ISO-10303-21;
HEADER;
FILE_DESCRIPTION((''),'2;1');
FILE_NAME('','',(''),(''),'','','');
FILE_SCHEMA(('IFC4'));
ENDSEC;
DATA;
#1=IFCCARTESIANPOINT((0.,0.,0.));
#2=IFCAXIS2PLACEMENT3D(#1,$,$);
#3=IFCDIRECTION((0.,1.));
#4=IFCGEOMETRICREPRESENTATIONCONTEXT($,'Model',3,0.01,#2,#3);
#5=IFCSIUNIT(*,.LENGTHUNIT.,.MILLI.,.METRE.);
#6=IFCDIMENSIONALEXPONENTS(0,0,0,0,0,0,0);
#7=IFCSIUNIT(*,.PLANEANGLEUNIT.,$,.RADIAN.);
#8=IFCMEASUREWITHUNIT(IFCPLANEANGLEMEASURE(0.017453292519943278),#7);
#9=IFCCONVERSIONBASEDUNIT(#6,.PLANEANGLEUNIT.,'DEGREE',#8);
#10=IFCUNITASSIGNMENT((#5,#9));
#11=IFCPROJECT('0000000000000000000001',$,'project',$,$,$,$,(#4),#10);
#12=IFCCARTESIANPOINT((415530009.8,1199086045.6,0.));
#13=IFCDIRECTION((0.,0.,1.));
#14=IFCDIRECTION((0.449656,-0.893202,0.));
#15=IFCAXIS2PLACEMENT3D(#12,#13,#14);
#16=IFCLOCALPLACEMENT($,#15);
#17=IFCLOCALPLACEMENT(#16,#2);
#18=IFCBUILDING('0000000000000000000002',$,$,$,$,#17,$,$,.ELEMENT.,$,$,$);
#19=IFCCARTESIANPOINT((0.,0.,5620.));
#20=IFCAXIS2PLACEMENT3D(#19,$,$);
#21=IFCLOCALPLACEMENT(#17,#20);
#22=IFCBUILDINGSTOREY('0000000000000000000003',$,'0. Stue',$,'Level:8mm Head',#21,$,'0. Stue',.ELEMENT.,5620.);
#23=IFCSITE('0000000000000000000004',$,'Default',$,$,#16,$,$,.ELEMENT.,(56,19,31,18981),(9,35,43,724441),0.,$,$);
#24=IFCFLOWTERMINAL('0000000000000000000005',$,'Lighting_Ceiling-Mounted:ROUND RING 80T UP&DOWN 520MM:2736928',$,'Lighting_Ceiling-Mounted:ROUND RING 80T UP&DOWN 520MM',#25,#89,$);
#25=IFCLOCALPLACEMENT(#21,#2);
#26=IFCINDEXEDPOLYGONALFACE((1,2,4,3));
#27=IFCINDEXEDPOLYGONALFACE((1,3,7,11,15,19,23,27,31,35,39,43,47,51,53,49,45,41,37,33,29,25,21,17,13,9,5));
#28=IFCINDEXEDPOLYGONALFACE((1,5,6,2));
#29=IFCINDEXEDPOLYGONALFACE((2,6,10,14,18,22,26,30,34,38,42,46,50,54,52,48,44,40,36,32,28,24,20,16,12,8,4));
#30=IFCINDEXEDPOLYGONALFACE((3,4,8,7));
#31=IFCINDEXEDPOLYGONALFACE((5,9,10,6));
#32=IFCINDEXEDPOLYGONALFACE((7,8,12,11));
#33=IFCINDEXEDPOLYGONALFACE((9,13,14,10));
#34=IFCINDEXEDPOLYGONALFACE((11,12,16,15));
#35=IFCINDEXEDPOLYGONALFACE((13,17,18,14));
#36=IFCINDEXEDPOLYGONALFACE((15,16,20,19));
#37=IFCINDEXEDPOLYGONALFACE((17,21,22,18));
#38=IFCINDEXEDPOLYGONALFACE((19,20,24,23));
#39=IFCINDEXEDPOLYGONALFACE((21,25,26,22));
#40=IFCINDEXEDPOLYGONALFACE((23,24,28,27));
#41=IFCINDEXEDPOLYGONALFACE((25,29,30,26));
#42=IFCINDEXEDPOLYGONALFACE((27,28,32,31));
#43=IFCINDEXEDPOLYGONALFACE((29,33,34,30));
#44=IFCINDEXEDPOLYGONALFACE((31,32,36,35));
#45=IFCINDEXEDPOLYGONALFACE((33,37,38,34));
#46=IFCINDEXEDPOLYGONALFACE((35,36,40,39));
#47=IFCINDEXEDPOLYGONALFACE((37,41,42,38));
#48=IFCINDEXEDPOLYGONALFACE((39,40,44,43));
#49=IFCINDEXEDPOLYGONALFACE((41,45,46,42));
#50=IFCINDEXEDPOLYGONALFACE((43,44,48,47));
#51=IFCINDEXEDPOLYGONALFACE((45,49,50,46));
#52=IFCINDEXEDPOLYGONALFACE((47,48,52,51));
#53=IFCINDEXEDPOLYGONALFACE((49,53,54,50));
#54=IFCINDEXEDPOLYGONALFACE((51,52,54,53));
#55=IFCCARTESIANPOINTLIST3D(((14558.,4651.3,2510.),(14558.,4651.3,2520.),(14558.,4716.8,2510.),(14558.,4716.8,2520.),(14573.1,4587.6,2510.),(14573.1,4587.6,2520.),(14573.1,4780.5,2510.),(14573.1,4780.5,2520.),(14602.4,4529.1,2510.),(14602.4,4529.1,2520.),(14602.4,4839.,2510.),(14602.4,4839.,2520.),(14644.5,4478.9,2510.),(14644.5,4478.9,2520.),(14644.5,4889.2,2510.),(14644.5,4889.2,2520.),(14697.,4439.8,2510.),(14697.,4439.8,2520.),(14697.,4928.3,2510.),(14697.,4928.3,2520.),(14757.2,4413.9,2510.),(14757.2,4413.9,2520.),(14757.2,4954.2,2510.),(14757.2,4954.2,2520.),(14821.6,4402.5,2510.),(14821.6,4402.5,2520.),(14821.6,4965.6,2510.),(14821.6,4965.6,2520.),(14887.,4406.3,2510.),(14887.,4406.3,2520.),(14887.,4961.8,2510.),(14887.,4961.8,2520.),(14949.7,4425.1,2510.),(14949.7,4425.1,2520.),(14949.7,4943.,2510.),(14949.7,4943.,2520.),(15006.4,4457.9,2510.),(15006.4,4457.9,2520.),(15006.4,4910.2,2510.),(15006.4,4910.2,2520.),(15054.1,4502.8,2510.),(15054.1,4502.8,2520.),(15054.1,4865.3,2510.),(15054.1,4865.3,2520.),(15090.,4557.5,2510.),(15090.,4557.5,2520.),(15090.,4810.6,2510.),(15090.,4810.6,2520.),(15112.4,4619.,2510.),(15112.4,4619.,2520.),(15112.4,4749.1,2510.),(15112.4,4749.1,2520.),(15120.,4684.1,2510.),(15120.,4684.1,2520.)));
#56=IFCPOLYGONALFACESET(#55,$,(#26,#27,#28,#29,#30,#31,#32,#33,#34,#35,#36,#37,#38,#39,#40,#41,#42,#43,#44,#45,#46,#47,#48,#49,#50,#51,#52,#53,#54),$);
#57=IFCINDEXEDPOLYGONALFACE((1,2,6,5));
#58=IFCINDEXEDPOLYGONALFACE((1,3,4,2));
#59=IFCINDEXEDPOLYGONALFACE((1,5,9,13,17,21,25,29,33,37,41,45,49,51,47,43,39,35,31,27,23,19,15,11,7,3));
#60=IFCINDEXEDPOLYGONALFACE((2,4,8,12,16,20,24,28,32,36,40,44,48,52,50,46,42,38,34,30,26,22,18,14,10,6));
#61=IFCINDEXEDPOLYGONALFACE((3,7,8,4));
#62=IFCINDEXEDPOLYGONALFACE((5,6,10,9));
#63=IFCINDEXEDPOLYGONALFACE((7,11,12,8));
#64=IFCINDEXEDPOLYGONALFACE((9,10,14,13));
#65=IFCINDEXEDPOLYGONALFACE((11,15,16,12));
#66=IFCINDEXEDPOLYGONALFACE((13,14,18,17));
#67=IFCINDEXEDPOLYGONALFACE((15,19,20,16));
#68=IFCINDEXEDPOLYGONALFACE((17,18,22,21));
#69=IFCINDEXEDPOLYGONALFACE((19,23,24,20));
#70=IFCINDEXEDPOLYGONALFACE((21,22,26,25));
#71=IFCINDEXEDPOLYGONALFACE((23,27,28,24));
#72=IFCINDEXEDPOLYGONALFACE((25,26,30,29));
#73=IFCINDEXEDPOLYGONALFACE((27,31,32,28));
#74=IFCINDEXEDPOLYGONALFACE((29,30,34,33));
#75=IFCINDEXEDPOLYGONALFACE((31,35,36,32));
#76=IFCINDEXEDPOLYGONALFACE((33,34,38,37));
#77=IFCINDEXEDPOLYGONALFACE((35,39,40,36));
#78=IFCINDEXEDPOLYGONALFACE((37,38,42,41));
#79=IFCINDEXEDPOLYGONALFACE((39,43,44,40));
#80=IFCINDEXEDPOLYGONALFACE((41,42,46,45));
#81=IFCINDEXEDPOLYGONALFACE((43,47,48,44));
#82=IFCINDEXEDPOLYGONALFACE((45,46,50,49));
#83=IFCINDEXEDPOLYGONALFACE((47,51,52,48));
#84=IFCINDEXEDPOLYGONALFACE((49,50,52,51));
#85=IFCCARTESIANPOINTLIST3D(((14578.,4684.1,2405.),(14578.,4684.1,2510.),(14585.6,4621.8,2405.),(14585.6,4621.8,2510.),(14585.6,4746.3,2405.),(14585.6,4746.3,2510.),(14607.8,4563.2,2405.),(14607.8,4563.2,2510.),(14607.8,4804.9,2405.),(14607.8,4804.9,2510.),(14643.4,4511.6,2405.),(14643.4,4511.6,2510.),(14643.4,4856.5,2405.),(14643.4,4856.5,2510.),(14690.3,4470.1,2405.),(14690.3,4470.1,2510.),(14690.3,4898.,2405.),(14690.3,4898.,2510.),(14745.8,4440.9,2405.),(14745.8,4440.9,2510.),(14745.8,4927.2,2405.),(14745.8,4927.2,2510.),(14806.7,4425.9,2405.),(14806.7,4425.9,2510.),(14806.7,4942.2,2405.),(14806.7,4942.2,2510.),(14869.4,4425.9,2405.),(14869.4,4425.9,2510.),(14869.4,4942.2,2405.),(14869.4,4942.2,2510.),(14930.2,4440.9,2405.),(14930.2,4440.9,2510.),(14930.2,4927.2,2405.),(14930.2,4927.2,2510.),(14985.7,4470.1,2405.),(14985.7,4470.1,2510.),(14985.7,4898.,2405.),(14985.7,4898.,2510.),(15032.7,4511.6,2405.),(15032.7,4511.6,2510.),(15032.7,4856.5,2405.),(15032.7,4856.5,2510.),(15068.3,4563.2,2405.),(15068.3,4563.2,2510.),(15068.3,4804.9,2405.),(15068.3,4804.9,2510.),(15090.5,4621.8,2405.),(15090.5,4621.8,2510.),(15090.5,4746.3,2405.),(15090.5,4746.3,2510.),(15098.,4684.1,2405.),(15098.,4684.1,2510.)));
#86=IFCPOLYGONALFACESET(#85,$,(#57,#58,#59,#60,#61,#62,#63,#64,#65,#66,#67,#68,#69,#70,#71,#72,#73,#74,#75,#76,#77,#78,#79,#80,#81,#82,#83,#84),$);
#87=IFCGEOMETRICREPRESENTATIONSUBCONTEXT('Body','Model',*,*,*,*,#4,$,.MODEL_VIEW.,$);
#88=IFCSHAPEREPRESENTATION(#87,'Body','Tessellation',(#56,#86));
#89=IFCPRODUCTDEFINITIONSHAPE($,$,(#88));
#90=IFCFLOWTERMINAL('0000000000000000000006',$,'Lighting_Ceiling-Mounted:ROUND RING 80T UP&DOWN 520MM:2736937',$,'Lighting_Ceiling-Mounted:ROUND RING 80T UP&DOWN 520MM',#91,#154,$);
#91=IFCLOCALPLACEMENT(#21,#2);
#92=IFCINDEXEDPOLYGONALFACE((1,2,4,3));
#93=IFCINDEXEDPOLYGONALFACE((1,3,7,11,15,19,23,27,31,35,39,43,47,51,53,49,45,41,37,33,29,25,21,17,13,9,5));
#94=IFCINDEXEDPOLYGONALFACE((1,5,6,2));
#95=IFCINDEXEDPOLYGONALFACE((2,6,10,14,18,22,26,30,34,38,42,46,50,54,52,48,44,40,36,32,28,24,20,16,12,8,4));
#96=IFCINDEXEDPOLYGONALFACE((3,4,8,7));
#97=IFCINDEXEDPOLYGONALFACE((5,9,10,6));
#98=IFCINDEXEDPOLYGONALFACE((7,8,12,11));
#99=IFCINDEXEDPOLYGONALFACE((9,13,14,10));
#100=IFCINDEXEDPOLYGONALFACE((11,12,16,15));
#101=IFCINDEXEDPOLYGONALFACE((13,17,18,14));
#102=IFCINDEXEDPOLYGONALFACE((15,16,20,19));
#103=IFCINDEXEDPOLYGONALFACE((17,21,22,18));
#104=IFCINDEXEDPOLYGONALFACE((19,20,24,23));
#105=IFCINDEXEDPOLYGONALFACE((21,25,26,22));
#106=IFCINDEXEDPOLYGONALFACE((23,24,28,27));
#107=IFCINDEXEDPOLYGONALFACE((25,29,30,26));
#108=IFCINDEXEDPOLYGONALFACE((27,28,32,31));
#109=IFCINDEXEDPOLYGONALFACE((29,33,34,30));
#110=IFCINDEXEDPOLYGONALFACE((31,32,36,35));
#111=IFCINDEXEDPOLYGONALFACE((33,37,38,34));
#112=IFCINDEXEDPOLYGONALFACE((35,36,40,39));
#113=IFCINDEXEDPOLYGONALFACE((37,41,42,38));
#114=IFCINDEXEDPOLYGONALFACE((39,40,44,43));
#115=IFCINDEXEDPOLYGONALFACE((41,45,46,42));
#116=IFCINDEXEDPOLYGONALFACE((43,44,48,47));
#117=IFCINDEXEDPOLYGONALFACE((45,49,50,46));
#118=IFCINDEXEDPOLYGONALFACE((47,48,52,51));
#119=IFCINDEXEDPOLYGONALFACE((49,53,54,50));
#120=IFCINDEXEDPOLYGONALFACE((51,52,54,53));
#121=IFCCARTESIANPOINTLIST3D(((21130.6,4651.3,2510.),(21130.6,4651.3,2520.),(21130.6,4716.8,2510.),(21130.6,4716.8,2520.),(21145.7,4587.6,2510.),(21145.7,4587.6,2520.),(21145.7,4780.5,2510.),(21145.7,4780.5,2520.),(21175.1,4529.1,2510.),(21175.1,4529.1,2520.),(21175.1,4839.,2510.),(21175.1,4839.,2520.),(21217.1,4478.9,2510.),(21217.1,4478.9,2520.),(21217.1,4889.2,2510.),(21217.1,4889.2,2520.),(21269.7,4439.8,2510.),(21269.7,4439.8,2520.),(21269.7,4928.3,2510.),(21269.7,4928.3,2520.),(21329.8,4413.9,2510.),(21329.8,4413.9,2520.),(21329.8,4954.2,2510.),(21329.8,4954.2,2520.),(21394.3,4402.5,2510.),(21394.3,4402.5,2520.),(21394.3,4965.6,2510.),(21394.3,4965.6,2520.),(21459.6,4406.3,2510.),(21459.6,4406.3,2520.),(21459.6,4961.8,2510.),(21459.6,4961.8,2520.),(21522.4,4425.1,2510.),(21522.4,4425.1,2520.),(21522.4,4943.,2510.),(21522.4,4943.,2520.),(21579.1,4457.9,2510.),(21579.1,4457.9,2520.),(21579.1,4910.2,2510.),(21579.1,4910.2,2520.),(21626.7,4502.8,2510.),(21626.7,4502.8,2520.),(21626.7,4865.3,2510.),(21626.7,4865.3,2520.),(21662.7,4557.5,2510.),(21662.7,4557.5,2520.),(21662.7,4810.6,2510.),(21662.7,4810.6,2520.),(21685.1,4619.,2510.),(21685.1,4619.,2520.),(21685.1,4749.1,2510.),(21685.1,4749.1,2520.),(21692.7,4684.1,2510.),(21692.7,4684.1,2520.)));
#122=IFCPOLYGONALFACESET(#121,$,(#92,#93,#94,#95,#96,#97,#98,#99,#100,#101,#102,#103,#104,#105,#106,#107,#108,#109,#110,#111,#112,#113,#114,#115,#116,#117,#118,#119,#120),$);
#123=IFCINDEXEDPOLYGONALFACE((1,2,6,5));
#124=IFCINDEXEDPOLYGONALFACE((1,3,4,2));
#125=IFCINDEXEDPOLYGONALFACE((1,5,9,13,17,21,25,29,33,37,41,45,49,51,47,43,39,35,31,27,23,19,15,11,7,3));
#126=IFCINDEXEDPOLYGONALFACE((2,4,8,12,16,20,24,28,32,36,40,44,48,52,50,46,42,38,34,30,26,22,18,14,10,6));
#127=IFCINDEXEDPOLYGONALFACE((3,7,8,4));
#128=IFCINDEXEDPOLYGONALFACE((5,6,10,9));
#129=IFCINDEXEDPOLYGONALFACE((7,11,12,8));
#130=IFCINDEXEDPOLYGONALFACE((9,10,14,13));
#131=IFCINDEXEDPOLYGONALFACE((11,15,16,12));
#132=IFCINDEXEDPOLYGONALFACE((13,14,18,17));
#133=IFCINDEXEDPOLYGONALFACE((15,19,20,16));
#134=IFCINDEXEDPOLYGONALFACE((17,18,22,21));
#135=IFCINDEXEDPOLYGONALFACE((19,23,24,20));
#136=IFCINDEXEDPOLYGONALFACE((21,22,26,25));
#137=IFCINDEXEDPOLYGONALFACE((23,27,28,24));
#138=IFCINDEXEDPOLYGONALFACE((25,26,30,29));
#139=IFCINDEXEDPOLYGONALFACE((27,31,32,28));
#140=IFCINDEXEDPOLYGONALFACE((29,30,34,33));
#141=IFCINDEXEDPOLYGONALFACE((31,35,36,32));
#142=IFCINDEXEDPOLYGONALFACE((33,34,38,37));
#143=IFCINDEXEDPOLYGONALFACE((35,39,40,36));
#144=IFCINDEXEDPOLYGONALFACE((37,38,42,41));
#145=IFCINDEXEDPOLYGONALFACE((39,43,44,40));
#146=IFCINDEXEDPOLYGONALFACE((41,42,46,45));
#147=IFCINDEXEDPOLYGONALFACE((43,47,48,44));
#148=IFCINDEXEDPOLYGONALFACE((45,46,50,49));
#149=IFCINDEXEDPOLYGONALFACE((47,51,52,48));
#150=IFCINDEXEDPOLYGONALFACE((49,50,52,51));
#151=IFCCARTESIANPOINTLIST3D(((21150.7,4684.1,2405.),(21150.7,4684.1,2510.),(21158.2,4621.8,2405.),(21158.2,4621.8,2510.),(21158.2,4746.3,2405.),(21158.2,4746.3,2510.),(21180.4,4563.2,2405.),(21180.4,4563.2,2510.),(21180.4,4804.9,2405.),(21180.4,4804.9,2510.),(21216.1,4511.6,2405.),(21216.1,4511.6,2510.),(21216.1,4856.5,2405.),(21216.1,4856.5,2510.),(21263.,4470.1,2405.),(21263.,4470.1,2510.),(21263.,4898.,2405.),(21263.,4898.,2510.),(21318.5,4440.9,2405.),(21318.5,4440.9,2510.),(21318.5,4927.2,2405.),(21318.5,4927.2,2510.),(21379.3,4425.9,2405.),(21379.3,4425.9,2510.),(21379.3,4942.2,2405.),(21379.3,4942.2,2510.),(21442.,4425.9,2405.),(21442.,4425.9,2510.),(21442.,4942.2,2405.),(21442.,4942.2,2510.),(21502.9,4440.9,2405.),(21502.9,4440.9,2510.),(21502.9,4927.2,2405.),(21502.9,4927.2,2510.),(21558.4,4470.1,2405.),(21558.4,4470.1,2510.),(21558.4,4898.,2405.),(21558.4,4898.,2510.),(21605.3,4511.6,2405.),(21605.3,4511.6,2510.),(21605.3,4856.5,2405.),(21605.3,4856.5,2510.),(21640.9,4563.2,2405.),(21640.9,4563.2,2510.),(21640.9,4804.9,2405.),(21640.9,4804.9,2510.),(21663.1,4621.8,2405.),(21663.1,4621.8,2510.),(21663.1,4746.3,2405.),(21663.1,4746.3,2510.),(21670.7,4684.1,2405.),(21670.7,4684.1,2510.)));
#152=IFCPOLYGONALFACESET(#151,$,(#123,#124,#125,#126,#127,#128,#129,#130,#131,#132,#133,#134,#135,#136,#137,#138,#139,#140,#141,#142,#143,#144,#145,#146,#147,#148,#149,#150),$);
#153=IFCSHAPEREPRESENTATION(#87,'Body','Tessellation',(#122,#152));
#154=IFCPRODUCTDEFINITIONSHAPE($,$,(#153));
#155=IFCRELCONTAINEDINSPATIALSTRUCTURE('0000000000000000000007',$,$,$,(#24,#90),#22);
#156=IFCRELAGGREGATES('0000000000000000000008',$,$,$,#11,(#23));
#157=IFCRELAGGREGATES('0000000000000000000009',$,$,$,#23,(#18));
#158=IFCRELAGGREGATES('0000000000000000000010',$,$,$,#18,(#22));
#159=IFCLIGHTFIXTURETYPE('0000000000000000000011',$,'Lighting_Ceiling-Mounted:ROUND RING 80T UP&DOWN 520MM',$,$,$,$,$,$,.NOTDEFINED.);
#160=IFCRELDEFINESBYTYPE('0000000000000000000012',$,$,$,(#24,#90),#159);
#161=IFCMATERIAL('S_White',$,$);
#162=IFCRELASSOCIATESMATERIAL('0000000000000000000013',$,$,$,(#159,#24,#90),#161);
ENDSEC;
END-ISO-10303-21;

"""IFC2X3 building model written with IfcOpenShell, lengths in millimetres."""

from ifc_helpers import new_model, entity, si_unit, converted_unit, direction, frame, frame_2d, origin, place, context, subcontext, project, spatial, circle, extrude, source, transform, mapped, material, type_object, type_shapes, element, save


model = new_model("IFC2X3")

# Units and contexts
model_context = context("Model", 3, precision=0.01, world=origin(), true_north=direction((0.0, 1.0)))
body_context = subcontext(model_context, "Body", "Model", "MODEL_VIEW")
ifc_project = project(units=[si_unit("LENGTHUNIT", "METRE", prefix="MILLI"), converted_unit("PLANEANGLEUNIT", "DEGREE", entity("IfcPlaneAngleMeasure", 0.017453292519943278), si_unit("PLANEANGLEUNIT", "RADIAN"), dimensions=[0, 0, 0, 0, 0, 0, 0])], contexts=[model_context])

# Site, building, storey
site_placement = place(None, frame((415530009.8, 1199086045.6, 0.0), z_axis=(0.0, 0.0, 1.0), x_axis=(0.449656, -0.893202, 0.0)))
site = spatial("IfcSite", under=ifc_project, at=site_placement, Name="Default", CompositionType="ELEMENT", RefLatitude=(56, 19, 31, 18981), RefLongitude=(9, 35, 43, 724441), RefElevation=0.0)
building_placement = place(site_placement, origin())
building = spatial("IfcBuilding", under=site, at=building_placement, CompositionType="ELEMENT")
storey_placement = place(building_placement, frame((0.0, 0.0, 5620.0)))
storey = spatial("IfcBuildingStorey", under=building, at=storey_placement, Name="0. Stue", ObjectType="Level:8mm Head", LongName="0. Stue", CompositionType="ELEMENT", Elevation=5620.0)

# Flow terminals
ifc_material_1 = material(Name="S_White")
light_fixture_type_1 = type_object("IfcLightFixtureType", Name="Lighting_Ceiling-Mounted:ROUND RING 80T UP&DOWN 520MM", PredefinedType="NOTDEFINED", material=ifc_material_1)
shared_shape_1 = source(origin(), body_context, "Body", "SweptSolid", [
    extrude(circle(Radius=282.0, at=frame_2d((0.0, 0.0), x_axis=(1.0, 0.0))), frame((0.0, 0.0, -10.0)), (0.0, 0.0, 1.0), 10.0),
    extrude(circle(Radius=260.0, at=frame_2d((0.0, 0.0), x_axis=(1.0, 0.0))), frame((0.0, 0.0, -115.0)), (0.0, 0.0, 1.0), 105.0),
])
type_shapes(light_fixture_type_1, [shared_shape_1])
for number, where, name in (
    (1, (14838.0, 4684.1, 2520.0), "Lighting_Ceiling-Mounted:ROUND RING 80T UP&DOWN 520MM:2736928"),
    (2, (21410.7, 4684.1, 2520.0), "Lighting_Ceiling-Mounted:ROUND RING 80T UP&DOWN 520MM:2736937"),
):
    element("IfcFlowTerminal", number, at=place(storey_placement, frame(where)), inside=storey, type_object=light_fixture_type_1, material=ifc_material_1, Name=name, ObjectType="Lighting_Ceiling-Mounted:ROUND RING 80T UP&DOWN 520MM", context=body_context, shape_type="MappedRepresentation", body=[
        mapped(shared_shape_1, transform((0.0, 0.0, 0.0), scale=1.0)),
    ])

save(model, "model.ifc")
